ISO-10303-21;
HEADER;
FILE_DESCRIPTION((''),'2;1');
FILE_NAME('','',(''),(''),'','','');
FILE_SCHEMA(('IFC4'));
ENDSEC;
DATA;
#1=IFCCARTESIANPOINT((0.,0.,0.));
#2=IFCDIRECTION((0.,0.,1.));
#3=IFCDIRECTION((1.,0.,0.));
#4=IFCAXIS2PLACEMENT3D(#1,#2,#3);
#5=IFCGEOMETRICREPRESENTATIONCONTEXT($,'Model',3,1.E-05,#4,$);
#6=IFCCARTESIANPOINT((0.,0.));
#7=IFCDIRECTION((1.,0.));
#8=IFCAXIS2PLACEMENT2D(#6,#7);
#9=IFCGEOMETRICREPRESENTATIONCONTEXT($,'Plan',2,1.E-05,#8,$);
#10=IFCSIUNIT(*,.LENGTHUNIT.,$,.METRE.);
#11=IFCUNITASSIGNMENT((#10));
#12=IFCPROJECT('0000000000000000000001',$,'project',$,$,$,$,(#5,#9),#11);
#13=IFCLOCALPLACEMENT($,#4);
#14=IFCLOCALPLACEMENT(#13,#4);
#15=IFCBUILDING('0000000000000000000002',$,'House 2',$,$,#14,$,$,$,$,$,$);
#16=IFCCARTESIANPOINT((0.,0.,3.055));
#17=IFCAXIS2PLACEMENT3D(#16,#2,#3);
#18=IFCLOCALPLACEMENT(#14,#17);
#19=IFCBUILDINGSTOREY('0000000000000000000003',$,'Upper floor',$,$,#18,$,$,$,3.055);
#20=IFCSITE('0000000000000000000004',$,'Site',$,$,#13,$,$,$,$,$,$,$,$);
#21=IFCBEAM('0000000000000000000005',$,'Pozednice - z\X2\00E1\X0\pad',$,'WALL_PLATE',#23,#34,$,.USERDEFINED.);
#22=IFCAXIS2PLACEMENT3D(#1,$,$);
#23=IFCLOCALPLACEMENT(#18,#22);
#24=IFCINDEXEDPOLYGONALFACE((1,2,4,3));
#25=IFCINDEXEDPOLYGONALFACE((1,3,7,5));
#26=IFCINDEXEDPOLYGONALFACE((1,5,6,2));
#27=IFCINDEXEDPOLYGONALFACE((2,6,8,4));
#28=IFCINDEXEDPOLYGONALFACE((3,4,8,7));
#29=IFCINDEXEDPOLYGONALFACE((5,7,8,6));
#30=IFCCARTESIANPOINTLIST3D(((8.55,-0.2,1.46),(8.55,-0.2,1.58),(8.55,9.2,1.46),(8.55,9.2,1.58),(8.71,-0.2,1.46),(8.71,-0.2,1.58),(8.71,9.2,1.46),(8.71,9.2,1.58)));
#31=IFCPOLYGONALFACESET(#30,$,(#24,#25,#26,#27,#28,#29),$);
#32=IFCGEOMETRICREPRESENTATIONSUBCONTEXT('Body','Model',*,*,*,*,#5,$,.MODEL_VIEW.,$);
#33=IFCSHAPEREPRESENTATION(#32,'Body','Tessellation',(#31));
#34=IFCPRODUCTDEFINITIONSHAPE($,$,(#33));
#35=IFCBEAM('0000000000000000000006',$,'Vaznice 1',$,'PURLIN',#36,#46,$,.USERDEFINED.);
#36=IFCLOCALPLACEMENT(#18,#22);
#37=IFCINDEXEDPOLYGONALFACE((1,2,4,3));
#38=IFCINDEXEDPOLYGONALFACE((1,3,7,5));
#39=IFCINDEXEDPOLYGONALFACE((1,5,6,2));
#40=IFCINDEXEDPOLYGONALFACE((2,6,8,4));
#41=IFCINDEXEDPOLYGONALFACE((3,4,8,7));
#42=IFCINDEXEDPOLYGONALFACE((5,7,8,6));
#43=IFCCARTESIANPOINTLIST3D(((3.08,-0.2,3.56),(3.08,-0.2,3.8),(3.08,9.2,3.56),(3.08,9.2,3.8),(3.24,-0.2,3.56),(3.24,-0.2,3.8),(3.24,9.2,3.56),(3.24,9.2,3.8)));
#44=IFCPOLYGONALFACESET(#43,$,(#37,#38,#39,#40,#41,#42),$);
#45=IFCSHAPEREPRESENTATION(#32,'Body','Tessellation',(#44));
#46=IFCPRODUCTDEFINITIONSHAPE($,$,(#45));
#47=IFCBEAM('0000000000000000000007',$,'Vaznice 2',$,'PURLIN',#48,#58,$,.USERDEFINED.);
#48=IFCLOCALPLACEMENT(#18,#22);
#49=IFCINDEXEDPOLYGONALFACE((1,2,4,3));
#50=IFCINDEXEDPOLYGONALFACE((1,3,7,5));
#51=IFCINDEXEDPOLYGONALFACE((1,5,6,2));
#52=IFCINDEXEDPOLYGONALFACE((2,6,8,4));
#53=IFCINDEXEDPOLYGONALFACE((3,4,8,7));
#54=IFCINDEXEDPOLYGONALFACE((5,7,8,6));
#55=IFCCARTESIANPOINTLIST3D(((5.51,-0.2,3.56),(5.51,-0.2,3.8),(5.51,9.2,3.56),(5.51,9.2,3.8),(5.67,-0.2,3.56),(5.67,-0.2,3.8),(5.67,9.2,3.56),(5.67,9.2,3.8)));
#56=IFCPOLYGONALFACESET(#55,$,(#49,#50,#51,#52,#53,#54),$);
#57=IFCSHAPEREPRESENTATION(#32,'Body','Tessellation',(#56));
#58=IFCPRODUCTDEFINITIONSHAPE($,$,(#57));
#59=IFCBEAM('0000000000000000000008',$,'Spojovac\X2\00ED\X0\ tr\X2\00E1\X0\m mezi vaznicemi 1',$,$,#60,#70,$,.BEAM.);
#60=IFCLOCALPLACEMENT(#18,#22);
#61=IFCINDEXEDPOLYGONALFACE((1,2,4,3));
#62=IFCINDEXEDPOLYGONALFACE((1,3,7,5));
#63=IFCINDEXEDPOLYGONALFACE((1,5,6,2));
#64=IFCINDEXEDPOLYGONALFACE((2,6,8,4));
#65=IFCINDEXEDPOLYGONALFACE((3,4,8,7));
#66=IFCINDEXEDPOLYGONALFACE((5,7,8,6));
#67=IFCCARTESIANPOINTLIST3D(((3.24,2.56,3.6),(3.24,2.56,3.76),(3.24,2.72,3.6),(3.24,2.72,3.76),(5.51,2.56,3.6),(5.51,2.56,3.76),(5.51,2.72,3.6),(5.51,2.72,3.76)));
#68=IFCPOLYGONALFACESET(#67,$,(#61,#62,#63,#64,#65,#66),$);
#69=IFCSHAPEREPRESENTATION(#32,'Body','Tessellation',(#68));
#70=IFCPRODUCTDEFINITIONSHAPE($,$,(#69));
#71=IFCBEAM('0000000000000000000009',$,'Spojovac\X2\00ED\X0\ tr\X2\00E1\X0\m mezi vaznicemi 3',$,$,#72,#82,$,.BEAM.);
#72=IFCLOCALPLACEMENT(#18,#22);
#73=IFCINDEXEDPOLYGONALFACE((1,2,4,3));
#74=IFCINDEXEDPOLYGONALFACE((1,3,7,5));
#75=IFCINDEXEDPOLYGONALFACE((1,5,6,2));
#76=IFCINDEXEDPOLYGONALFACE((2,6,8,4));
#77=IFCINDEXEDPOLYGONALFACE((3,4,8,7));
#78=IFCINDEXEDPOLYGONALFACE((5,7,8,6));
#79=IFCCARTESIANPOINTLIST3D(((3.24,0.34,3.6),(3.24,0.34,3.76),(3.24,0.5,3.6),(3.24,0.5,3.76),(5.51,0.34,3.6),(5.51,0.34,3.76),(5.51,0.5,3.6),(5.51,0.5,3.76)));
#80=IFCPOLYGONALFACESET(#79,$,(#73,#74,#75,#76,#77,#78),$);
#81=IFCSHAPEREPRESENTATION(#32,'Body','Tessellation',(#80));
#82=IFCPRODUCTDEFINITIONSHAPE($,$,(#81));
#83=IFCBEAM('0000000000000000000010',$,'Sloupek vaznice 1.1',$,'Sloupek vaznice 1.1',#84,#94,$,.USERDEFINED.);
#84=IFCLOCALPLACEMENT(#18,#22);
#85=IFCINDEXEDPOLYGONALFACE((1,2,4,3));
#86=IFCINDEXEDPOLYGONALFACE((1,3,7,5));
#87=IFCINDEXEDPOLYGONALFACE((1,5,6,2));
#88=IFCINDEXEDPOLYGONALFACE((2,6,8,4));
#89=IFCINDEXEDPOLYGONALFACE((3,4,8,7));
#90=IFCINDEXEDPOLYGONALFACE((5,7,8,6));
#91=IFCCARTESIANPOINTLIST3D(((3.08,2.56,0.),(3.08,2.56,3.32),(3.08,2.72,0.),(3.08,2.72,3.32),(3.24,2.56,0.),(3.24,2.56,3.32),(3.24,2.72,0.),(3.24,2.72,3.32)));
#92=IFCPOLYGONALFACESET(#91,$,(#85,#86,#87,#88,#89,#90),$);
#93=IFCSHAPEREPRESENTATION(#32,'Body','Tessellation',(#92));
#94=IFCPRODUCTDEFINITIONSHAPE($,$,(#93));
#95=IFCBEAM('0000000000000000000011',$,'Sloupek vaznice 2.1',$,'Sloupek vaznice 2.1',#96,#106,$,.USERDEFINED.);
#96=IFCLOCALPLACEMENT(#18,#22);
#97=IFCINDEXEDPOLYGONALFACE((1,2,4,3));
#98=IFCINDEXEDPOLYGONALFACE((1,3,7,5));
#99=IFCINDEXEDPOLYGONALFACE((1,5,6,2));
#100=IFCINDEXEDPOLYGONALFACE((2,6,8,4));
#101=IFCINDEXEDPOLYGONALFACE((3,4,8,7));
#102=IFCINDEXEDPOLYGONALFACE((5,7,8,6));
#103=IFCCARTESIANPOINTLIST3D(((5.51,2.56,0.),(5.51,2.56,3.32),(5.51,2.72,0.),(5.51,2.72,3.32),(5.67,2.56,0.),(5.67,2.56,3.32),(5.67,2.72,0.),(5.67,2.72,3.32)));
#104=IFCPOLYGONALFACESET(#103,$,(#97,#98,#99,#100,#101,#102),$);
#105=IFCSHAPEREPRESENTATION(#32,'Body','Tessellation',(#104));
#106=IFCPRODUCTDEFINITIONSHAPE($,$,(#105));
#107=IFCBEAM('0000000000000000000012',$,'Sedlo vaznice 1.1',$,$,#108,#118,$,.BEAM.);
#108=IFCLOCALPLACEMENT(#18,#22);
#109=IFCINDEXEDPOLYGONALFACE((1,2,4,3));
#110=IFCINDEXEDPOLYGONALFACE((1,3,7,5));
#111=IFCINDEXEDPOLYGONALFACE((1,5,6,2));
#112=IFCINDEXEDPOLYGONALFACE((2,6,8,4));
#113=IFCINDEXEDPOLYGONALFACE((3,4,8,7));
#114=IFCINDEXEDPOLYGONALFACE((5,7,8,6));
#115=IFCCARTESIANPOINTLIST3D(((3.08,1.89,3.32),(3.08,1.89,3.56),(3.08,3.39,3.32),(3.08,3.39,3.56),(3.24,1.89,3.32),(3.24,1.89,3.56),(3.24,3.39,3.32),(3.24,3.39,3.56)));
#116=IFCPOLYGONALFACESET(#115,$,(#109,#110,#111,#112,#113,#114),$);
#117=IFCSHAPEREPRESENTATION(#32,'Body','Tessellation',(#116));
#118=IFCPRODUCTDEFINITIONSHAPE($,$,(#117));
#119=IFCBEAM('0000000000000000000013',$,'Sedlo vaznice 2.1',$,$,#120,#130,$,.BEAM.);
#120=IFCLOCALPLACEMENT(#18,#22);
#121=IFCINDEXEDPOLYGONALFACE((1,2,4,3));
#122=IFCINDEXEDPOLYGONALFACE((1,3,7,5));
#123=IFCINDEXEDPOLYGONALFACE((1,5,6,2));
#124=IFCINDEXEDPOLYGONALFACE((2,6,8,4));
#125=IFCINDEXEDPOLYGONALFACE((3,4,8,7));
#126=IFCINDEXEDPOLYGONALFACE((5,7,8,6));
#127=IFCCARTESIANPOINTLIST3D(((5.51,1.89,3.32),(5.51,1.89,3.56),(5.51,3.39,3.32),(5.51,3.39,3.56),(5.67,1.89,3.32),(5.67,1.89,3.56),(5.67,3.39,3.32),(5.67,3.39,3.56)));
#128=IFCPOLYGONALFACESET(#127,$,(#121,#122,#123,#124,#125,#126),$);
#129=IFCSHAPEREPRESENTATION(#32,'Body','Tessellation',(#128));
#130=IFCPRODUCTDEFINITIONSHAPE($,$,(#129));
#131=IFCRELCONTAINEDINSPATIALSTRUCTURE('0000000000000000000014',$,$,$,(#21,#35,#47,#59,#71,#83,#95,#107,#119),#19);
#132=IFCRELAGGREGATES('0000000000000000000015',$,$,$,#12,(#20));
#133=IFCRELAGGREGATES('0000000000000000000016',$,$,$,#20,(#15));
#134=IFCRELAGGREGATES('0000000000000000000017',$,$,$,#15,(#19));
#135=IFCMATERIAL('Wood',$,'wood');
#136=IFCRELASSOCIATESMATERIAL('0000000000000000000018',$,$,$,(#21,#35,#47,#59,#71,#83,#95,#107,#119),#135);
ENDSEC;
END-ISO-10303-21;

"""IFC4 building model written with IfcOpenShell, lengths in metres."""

from ifc_helpers import new_model, si_unit, frame, origin_with_axes, origin_2d_with_axis, place, context, subcontext, project, spatial, rectangle, extrude, material, element, save


model = new_model("IFC4")

# Units and contexts
model_context = context("Model", 3, precision=1e-05, world=origin_with_axes())
plan_context = context("Plan", 2, precision=1e-05, world=origin_2d_with_axis())
body_context_1 = subcontext(model_context, "Body", "Model", "MODEL_VIEW")
ifc_project = project(units=[si_unit("LENGTHUNIT", "METRE")], contexts=[model_context, plan_context])

# Site, building, storey
site_placement = place(None, origin_with_axes())
site = spatial("IfcSite", under=ifc_project, at=site_placement, Name="Site")
building_placement = place(site_placement, origin_with_axes())
building = spatial("IfcBuilding", under=site, at=building_placement, Name="House 2")
storey_placement = place(building_placement, frame((0.0, 0.0, 3.055), z_axis=(0.0, 0.0, 1.0), x_axis=(1.0, 0.0, 0.0)))
storey = spatial("IfcBuildingStorey", under=building, at=storey_placement, Name="Upper floor", Elevation=3.055)

# Beams
ifc_material_1 = material(Name="Wood", Category="wood")
beam_1_placement = place(storey_placement, frame((8.63, -0.2, 1.52), z_axis=(0.0, 0.0, 1.0), x_axis=(0.0, 1.0, 0.0)))
element("IfcBeam", 1, at=beam_1_placement, inside=storey, material=ifc_material_1, Name="Pozednice - západ", ObjectType="WALL_PLATE", PredefinedType="USERDEFINED", context=body_context_1, shape_type="SweptSolid", body=[
    extrude(rectangle(XDim=0.16, YDim=0.12), frame((0.0, 0.0, 0.0), z_axis=(1.0, 0.0, 0.0), x_axis=(0.0, 1.0, 0.0)), (0.0, 0.0, 1.0), 9.4),
])
for number, where, z_axis, x_axis, name in (
    (2, (3.16, -0.2, 3.68), (0.0, 0.0, 1.0), (0.0, 1.0, 0.0), "Vaznice 1"),
    (3, (5.59, -0.2, 3.68), (0.0, 0.0, 1.0), (0.0, 1.0, 0.0), "Vaznice 2"),
):
    element("IfcBeam", number, at=place(storey_placement, frame(where, z_axis=z_axis, x_axis=x_axis)), inside=storey, material=ifc_material_1, Name=name, ObjectType="PURLIN", PredefinedType="USERDEFINED", context=body_context_1, shape_type="SweptSolid", body=[
        extrude(rectangle(XDim=0.16, YDim=0.24), frame((0.0, 0.0, 0.0), z_axis=(1.0, 0.0, 0.0), x_axis=(0.0, 1.0, 0.0)), (0.0, 0.0, 1.0), 9.4),
    ])
for number, where, z_axis, x_axis, name in (
    (4, (3.24, 2.64, 3.68), (0.0, 0.0, 1.0), (1.0, 0.0, 0.0), "Spojovací trám mezi vaznicemi 1"),
    (5, (3.24, 0.42, 3.68), (0.0, 0.0, 1.0), (1.0, 0.0, 0.0), "Spojovací trám mezi vaznicemi 3"),
):
    element("IfcBeam", number, at=place(storey_placement, frame(where, z_axis=z_axis, x_axis=x_axis)), inside=storey, material=ifc_material_1, Name=name, PredefinedType="BEAM", context=body_context_1, shape_type="SweptSolid", body=[
        extrude(rectangle(XDim=0.16, YDim=0.16), frame((0.0, 0.0, 0.0), z_axis=(1.0, 0.0, 0.0), x_axis=(0.0, 1.0, 0.0)), (0.0, 0.0, 1.0), 2.27),
    ])
beam_2_placement = place(storey_placement, frame((3.16, 2.64, 0.0), z_axis=(0.0, 1.0, 0.0), x_axis=(0.0, 0.0, 1.0)))
element("IfcBeam", 6, at=beam_2_placement, inside=storey, material=ifc_material_1, Name="Sloupek vaznice 1.1", ObjectType="Sloupek vaznice 1.1", PredefinedType="USERDEFINED", context=body_context_1, shape_type="SweptSolid", body=[
    extrude(rectangle(XDim=0.16, YDim=0.16), frame((0.0, 0.0, 0.0), z_axis=(1.0, 0.0, 0.0), x_axis=(0.0, 1.0, 0.0)), (0.0, 0.0, 1.0), 3.32),
])
beam_3_placement = place(storey_placement, frame((5.59, 2.64, 0.0), z_axis=(0.0, 1.0, 0.0), x_axis=(0.0, 0.0, 1.0)))
element("IfcBeam", 7, at=beam_3_placement, inside=storey, material=ifc_material_1, Name="Sloupek vaznice 2.1", ObjectType="Sloupek vaznice 2.1", PredefinedType="USERDEFINED", context=body_context_1, shape_type="SweptSolid", body=[
    extrude(rectangle(XDim=0.16, YDim=0.16), frame((0.0, 0.0, 0.0), z_axis=(1.0, 0.0, 0.0), x_axis=(0.0, 1.0, 0.0)), (0.0, 0.0, 1.0), 3.32),
])
for number, where, z_axis, x_axis, name in (
    (8, (3.16, 1.89, 3.44), (0.0, 0.0, 1.0), (0.0, 1.0, 0.0), "Sedlo vaznice 1.1"),
    (9, (5.59, 1.89, 3.44), (0.0, 0.0, 1.0), (0.0, 1.0, 0.0), "Sedlo vaznice 2.1"),
):
    element("IfcBeam", number, at=place(storey_placement, frame(where, z_axis=z_axis, x_axis=x_axis)), inside=storey, material=ifc_material_1, Name=name, PredefinedType="BEAM", context=body_context_1, shape_type="SweptSolid", body=[
        extrude(rectangle(XDim=0.16, YDim=0.24), frame((0.0, 0.0, 0.0), z_axis=(1.0, 0.0, 0.0), x_axis=(0.0, 1.0, 0.0)), (0.0, 0.0, 1.0), 1.5),
    ])

save(model, "model.ifc")
